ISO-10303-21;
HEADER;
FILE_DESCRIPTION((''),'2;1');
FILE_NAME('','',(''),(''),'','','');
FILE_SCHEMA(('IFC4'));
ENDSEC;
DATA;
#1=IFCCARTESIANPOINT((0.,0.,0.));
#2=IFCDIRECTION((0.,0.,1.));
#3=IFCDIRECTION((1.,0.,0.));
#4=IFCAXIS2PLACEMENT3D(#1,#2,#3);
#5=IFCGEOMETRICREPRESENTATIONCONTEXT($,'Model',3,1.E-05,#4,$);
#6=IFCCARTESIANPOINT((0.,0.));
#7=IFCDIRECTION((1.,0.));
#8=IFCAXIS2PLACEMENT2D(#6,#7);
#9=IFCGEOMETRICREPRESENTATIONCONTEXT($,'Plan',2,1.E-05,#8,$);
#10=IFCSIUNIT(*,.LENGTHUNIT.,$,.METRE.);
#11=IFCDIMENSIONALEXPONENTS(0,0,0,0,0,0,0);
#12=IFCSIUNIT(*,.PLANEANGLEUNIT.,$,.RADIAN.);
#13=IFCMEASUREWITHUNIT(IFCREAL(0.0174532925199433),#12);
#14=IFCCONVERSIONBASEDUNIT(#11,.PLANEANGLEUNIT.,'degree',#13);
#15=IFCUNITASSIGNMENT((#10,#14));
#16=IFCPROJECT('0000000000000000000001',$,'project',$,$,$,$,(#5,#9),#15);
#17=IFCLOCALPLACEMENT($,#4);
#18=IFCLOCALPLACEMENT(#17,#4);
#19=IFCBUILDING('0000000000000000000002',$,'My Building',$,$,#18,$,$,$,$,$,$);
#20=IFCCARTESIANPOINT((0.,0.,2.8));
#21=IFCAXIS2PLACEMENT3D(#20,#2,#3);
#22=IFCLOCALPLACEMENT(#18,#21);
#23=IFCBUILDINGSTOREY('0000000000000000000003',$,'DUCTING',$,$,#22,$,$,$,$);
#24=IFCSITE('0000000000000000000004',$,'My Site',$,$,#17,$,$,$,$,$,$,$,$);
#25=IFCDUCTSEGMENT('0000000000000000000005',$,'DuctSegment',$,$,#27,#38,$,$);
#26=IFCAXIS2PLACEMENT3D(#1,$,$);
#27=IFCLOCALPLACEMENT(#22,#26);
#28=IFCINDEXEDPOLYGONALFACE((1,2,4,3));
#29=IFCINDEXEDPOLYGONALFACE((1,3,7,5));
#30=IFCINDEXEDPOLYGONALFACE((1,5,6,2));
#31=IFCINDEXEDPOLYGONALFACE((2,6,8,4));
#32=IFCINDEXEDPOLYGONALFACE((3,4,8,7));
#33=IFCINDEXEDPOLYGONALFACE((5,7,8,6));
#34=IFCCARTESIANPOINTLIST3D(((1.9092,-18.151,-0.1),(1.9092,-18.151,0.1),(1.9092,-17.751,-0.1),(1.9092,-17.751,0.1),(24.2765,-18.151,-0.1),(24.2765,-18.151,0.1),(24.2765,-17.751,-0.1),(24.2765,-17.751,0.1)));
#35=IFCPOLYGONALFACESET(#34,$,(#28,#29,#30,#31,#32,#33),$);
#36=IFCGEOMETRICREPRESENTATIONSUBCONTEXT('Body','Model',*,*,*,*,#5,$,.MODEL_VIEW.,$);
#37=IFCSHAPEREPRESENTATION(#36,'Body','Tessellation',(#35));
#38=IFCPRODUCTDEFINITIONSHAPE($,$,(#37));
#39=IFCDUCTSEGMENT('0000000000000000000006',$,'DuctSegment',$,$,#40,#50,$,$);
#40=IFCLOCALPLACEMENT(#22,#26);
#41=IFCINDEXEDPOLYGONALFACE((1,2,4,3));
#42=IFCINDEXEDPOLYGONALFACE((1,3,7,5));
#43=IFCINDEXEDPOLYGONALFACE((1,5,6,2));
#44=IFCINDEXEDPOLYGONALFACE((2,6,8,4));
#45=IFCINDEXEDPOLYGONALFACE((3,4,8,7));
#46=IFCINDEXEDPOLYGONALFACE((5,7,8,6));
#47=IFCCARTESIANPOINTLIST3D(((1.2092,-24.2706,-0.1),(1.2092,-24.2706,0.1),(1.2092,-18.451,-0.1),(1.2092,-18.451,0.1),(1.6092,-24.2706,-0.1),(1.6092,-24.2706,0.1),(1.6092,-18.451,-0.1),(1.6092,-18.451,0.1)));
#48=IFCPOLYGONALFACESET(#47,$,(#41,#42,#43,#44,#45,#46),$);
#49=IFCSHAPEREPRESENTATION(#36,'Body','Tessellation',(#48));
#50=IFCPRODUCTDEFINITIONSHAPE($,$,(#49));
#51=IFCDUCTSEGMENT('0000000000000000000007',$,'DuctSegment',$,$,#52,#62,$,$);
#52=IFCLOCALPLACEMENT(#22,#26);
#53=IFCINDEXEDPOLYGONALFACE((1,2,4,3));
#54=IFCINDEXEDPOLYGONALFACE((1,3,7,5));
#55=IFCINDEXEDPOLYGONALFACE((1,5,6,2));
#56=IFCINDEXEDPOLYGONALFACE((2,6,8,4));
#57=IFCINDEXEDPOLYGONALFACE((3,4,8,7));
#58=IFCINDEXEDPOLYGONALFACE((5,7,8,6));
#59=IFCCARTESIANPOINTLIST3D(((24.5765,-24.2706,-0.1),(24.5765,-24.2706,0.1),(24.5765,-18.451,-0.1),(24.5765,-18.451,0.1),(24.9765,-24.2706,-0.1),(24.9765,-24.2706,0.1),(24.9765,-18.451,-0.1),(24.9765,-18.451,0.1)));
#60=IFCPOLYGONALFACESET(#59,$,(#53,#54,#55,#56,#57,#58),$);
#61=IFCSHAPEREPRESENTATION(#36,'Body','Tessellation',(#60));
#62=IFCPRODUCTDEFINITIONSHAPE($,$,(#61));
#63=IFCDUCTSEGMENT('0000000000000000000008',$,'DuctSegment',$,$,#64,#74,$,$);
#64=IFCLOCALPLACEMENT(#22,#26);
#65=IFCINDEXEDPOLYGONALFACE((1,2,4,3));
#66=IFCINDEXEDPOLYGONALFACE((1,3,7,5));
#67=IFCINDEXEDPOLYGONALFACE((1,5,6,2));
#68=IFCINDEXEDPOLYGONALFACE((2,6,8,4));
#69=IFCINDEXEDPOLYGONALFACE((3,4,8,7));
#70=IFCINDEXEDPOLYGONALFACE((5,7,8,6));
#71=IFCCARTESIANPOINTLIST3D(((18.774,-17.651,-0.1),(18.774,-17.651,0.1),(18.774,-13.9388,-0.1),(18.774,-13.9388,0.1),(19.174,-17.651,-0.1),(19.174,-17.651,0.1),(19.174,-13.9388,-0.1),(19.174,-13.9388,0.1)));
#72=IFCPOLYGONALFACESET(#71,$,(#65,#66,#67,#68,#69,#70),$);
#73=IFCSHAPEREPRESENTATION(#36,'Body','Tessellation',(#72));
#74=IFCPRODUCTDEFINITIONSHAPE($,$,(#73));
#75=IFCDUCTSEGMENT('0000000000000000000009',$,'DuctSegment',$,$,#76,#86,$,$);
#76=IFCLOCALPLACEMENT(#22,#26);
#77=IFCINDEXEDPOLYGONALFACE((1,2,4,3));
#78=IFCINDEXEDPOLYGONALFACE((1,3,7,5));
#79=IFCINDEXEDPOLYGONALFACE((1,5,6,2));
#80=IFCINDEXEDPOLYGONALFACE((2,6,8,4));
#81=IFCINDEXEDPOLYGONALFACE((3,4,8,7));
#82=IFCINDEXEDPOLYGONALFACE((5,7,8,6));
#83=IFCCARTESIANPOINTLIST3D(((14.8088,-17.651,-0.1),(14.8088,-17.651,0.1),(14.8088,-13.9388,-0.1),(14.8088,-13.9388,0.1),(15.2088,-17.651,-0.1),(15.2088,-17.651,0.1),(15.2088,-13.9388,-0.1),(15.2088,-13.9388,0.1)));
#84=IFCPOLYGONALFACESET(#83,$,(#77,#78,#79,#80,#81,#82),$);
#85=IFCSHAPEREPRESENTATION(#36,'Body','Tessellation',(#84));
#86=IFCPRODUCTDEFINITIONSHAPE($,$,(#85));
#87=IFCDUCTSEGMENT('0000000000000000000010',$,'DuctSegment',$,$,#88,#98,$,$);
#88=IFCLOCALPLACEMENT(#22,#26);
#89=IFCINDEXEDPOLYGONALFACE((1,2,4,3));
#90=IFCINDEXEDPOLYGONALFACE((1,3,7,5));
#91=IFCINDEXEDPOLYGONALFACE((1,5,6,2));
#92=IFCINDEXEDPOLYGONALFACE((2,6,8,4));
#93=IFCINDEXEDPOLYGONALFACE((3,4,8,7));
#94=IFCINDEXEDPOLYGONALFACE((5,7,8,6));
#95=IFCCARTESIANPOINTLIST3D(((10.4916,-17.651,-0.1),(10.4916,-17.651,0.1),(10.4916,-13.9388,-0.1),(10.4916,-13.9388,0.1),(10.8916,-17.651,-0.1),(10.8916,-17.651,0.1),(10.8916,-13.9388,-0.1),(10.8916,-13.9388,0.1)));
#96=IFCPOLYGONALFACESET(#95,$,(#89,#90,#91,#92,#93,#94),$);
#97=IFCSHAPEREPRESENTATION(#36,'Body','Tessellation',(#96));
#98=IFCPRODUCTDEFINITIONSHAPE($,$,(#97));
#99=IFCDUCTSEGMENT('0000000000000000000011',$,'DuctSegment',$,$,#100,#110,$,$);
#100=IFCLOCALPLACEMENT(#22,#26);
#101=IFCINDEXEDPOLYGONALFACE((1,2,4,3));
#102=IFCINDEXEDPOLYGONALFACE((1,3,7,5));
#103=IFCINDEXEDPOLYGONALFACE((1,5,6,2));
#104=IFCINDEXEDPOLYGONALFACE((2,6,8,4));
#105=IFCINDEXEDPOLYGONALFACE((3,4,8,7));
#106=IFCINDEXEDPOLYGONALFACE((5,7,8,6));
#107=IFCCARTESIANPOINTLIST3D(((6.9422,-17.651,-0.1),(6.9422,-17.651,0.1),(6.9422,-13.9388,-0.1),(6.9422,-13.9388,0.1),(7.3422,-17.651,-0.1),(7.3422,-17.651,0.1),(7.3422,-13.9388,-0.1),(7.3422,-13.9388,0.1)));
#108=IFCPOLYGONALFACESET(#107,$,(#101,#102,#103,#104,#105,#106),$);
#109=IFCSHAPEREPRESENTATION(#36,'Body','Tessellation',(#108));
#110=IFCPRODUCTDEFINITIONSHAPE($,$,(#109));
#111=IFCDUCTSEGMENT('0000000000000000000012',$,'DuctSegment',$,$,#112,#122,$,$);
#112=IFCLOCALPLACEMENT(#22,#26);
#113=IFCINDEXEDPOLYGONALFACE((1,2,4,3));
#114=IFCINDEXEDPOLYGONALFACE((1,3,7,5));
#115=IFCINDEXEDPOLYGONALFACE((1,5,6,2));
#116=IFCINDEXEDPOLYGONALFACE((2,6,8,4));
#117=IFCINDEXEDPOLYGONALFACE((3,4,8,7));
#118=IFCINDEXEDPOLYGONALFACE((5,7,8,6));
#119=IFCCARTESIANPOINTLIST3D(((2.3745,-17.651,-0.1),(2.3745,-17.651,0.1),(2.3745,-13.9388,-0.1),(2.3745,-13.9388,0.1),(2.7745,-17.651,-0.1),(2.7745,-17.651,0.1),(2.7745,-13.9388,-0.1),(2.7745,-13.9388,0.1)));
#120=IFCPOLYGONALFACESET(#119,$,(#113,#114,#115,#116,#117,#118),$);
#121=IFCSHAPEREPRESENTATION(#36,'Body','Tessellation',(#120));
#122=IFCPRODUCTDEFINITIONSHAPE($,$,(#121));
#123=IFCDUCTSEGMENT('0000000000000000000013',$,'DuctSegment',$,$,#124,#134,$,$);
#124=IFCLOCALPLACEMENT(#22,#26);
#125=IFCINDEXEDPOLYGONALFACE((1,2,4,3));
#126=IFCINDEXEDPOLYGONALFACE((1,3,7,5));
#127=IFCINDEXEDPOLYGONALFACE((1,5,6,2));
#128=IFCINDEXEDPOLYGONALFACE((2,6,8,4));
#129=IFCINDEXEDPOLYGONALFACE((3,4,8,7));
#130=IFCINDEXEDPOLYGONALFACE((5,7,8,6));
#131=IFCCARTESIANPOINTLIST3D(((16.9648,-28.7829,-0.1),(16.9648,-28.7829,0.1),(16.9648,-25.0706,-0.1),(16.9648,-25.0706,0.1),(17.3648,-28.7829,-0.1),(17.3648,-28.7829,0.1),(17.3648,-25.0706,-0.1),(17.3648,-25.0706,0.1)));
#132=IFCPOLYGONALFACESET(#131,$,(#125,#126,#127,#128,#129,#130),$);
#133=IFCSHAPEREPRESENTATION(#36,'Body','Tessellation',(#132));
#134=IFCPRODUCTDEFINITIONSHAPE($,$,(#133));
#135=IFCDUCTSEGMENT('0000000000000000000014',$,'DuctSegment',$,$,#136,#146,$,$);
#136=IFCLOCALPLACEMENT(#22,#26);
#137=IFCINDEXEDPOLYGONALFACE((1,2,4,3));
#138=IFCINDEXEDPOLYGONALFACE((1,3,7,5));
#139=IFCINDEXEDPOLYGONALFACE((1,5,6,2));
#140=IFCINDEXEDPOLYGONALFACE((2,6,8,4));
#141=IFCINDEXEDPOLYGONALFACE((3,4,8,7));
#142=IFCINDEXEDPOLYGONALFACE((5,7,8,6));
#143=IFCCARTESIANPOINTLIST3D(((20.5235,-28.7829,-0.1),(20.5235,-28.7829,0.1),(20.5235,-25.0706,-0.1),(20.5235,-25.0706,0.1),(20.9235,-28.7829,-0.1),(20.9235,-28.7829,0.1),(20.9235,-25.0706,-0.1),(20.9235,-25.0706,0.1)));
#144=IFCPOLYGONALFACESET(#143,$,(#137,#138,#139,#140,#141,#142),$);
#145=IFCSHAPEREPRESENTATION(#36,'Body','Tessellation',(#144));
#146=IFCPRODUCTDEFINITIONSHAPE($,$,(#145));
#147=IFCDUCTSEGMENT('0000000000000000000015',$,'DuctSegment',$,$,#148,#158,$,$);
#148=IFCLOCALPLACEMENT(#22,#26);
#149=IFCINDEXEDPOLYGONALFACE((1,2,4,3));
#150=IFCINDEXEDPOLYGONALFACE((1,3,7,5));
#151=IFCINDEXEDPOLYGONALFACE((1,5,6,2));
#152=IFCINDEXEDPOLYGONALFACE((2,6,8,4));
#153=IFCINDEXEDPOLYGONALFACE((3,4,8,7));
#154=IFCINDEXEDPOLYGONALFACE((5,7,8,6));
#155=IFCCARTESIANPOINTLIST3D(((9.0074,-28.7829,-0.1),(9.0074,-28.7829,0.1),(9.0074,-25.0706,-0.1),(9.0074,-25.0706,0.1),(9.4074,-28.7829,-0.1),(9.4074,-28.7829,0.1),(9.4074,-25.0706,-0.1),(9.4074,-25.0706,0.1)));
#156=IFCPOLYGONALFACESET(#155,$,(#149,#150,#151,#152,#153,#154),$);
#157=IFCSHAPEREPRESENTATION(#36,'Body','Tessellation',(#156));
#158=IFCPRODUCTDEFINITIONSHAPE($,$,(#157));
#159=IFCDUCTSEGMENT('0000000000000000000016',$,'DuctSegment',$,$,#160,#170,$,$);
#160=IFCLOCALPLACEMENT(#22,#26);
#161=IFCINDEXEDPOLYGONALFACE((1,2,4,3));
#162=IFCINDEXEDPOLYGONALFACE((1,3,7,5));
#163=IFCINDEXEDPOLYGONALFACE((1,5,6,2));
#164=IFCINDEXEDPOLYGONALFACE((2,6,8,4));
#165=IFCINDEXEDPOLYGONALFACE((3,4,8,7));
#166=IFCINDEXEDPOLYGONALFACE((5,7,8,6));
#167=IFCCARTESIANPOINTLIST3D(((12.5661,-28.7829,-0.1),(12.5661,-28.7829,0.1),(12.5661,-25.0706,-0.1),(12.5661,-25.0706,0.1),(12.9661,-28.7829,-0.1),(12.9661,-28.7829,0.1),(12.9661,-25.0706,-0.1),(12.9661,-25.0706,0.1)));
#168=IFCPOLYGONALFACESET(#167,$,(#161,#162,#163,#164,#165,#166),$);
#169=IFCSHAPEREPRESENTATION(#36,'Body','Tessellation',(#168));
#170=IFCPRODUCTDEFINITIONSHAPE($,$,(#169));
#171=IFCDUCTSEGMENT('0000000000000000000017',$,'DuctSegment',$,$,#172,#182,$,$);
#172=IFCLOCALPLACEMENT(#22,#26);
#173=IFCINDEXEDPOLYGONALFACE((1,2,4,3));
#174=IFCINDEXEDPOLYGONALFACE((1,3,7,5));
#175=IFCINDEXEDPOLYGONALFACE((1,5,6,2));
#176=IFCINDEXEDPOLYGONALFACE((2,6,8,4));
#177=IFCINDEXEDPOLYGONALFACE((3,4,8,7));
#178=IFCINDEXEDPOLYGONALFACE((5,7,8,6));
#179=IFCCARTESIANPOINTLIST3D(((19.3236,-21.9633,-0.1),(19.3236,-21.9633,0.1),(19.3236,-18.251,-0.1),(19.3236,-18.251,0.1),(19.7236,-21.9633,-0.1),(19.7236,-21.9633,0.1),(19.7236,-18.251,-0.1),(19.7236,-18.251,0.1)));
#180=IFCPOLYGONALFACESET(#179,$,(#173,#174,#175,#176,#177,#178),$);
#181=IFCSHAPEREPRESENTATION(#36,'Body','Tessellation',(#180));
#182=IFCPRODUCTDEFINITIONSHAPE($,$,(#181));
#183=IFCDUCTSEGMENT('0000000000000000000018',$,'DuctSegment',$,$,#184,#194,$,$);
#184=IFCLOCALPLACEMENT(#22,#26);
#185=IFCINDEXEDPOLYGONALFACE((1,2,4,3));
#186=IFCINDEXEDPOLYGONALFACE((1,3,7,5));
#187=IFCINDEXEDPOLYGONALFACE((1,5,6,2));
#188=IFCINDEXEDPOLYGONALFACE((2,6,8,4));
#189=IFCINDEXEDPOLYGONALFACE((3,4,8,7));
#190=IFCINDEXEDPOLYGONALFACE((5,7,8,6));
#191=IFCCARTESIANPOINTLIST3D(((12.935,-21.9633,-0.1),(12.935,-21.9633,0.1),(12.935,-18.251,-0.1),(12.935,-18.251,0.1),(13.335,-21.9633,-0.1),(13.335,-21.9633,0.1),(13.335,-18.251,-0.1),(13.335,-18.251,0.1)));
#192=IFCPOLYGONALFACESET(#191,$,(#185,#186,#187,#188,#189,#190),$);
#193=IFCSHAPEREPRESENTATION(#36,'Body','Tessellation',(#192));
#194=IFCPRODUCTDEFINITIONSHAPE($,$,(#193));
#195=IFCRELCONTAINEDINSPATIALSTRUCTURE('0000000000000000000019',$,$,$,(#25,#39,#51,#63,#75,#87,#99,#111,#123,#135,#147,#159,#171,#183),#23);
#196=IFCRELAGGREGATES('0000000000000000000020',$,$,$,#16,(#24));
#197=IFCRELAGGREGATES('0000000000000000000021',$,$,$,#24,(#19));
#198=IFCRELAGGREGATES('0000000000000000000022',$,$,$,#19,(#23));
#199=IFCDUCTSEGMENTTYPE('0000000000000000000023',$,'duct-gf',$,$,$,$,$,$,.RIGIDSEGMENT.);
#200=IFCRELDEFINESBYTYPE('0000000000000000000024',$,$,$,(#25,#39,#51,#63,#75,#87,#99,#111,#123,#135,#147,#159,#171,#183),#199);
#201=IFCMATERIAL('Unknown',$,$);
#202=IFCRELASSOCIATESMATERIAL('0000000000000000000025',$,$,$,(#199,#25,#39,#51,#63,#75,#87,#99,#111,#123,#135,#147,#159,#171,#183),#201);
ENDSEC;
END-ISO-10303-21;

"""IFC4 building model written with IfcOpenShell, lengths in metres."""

from ifc_helpers import new_model, entity, si_unit, converted_unit, frame, origin_with_axes, origin_2d_with_axis, place, context, subcontext, project, spatial, rectangle, extrude, material, material_profile, profile_set, profile_usage, type_object, element, save


model = new_model("IFC4")

# Units and contexts
model_context = context("Model", 3, precision=1e-05, world=origin_with_axes())
plan_context = context("Plan", 2, precision=1e-05, world=origin_2d_with_axis())
body_context = subcontext(model_context, "Body", "Model", "MODEL_VIEW")
ifc_project = project(units=[si_unit("LENGTHUNIT", "METRE"), converted_unit("PLANEANGLEUNIT", "degree", entity("IfcReal", 0.0174532925199433), si_unit("PLANEANGLEUNIT", "RADIAN"), dimensions=[0, 0, 0, 0, 0, 0, 0])], contexts=[model_context, plan_context])

# Site, building, storey
site_placement = place(None, origin_with_axes())
site = spatial("IfcSite", under=ifc_project, at=site_placement, Name="My Site")
building_placement = place(site_placement, origin_with_axes())
building = spatial("IfcBuilding", under=site, at=building_placement, Name="My Building")
storey_placement = place(building_placement, frame((0.0, 0.0, 2.8), z_axis=(0.0, 0.0, 1.0), x_axis=(1.0, 0.0, 0.0)))
storey = spatial("IfcBuildingStorey", under=building, at=storey_placement, Name="DUCTING")

# Duct segments
ifc_material = material(Name="Unknown")
ifc_material_profile = material_profile(ifc_material, rectangle(XDim=0.4, YDim=0.2))
ifc_profile_set = profile_set([ifc_material_profile])
ifc_profile_usage_1 = profile_usage(ifc_profile_set, cardinal=5)
duct_segment_type = type_object("IfcDuctSegmentType", Name="duct-gf", PredefinedType="RIGIDSEGMENT", material=ifc_profile_set)
duct_segment_1_placement = place(storey_placement, frame((1.9092, -17.951, 0.0), z_axis=(1.0, -0.000001, 0.000001), x_axis=(0.000001, 1.0, 0.0)))
element("IfcDuctSegment", 1, at=duct_segment_1_placement, inside=storey, type_object=duct_segment_type, material=ifc_profile_usage_1, Name="DuctSegment", context=body_context, shape_type="SweptSolid", body=[
    extrude(rectangle(XDim=0.4, YDim=0.2), origin_with_axes(), (0.0, 0.0, 1.0), 22.3674),
])
ifc_profile_usage_2 = profile_usage(ifc_profile_set, cardinal=5)
duct_segment_2_placement = place(storey_placement, frame((1.4092, -18.451, 0.0), z_axis=(0.0, -1.0, 0.0), x_axis=(1.0, 0.0, 0.0)))
element("IfcDuctSegment", 2, at=duct_segment_2_placement, inside=storey, type_object=duct_segment_type, material=ifc_profile_usage_2, Name="DuctSegment", context=body_context, shape_type="SweptSolid", body=[
    extrude(rectangle(XDim=0.4, YDim=0.2), origin_with_axes(), (0.0, 0.0, 1.0), 5.8196),
])
ifc_profile_usage_3 = profile_usage(ifc_profile_set, cardinal=5)
duct_segment_3_placement = place(storey_placement, frame((24.7765, -18.451, 0.0), z_axis=(0.0, -1.0, 0.0), x_axis=(1.0, 0.0, 0.0)))
element("IfcDuctSegment", 3, at=duct_segment_3_placement, inside=storey, type_object=duct_segment_type, material=ifc_profile_usage_3, Name="DuctSegment", context=body_context, shape_type="SweptSolid", body=[
    extrude(rectangle(XDim=0.4, YDim=0.2), origin_with_axes(), (0.0, 0.0, 1.0), 5.8196),
])
ifc_profile_usage_4 = profile_usage(ifc_profile_set, cardinal=5)
duct_segment_4_placement = place(storey_placement, frame((18.974, -13.9388, 0.0), z_axis=(0.0, -1.0, 0.0), x_axis=(1.0, 0.0, 0.0)))
element("IfcDuctSegment", 4, at=duct_segment_4_placement, inside=storey, type_object=duct_segment_type, material=ifc_profile_usage_4, Name="DuctSegment", context=body_context, shape_type="SweptSolid", body=[
    extrude(rectangle(XDim=0.4, YDim=0.2), origin_with_axes(), (0.0, 0.0, 1.0), 3.7122),
])
ifc_profile_usage_5 = profile_usage(ifc_profile_set, cardinal=5)
duct_segment_5_placement = place(storey_placement, frame((15.0088, -13.9388, 0.0), z_axis=(0.0, -1.0, 0.0), x_axis=(1.0, 0.0, 0.0)))
element("IfcDuctSegment", 5, at=duct_segment_5_placement, inside=storey, type_object=duct_segment_type, material=ifc_profile_usage_5, Name="DuctSegment", context=body_context, shape_type="SweptSolid", body=[
    extrude(rectangle(XDim=0.4, YDim=0.2), origin_with_axes(), (0.0, 0.0, 1.0), 3.7122),
])
ifc_profile_usage_6 = profile_usage(ifc_profile_set, cardinal=5)
duct_segment_6_placement = place(storey_placement, frame((10.6916, -13.9388, 0.0), z_axis=(0.0, -1.0, 0.0), x_axis=(1.0, 0.0, 0.0)))
element("IfcDuctSegment", 6, at=duct_segment_6_placement, inside=storey, type_object=duct_segment_type, material=ifc_profile_usage_6, Name="DuctSegment", context=body_context, shape_type="SweptSolid", body=[
    extrude(rectangle(XDim=0.4, YDim=0.2), origin_with_axes(), (0.0, 0.0, 1.0), 3.7122),
])
ifc_profile_usage_7 = profile_usage(ifc_profile_set, cardinal=5)
duct_segment_7_placement = place(storey_placement, frame((7.1422, -13.9388, 0.0), z_axis=(0.0, -1.0, 0.0), x_axis=(1.0, 0.0, 0.0)))
element("IfcDuctSegment", 7, at=duct_segment_7_placement, inside=storey, type_object=duct_segment_type, material=ifc_profile_usage_7, Name="DuctSegment", context=body_context, shape_type="SweptSolid", body=[
    extrude(rectangle(XDim=0.4, YDim=0.2), origin_with_axes(), (0.0, 0.0, 1.0), 3.7122),
])
ifc_profile_usage_8 = profile_usage(ifc_profile_set, cardinal=5)
duct_segment_8_placement = place(storey_placement, frame((2.5745, -13.9388, 0.0), z_axis=(0.0, -1.0, 0.0), x_axis=(1.0, 0.0, 0.0)))
element("IfcDuctSegment", 8, at=duct_segment_8_placement, inside=storey, type_object=duct_segment_type, material=ifc_profile_usage_8, Name="DuctSegment", context=body_context, shape_type="SweptSolid", body=[
    extrude(rectangle(XDim=0.4, YDim=0.2), origin_with_axes(), (0.0, 0.0, 1.0), 3.7122),
])
ifc_profile_usage_9 = profile_usage(ifc_profile_set, cardinal=5)
duct_segment_9_placement = place(storey_placement, frame((17.1648, -28.7829, 0.0), z_axis=(0.0, 1.0, 0.0), x_axis=(-1.0, 0.0, 0.0)))
element("IfcDuctSegment", 9, at=duct_segment_9_placement, inside=storey, type_object=duct_segment_type, material=ifc_profile_usage_9, Name="DuctSegment", context=body_context, shape_type="SweptSolid", body=[
    extrude(rectangle(XDim=0.4, YDim=0.2), origin_with_axes(), (0.0, 0.0, 1.0), 3.7122),
])
ifc_profile_usage_10 = profile_usage(ifc_profile_set, cardinal=5)
duct_segment_10_placement = place(storey_placement, frame((20.7235, -28.7829, 0.0), z_axis=(0.0, 1.0, 0.0), x_axis=(-1.0, 0.0, 0.0)))
element("IfcDuctSegment", 10, at=duct_segment_10_placement, inside=storey, type_object=duct_segment_type, material=ifc_profile_usage_10, Name="DuctSegment", context=body_context, shape_type="SweptSolid", body=[
    extrude(rectangle(XDim=0.4, YDim=0.2), origin_with_axes(), (0.0, 0.0, 1.0), 3.7122),
])
ifc_profile_usage_11 = profile_usage(ifc_profile_set, cardinal=5)
duct_segment_11_placement = place(storey_placement, frame((9.2074, -28.7829, 0.0), z_axis=(0.0, 1.0, 0.0), x_axis=(-1.0, 0.0, 0.0)))
element("IfcDuctSegment", 11, at=duct_segment_11_placement, inside=storey, type_object=duct_segment_type, material=ifc_profile_usage_11, Name="DuctSegment", context=body_context, shape_type="SweptSolid", body=[
    extrude(rectangle(XDim=0.4, YDim=0.2), origin_with_axes(), (0.0, 0.0, 1.0), 3.7122),
])
ifc_profile_usage_12 = profile_usage(ifc_profile_set, cardinal=5)
duct_segment_12_placement = place(storey_placement, frame((12.7661, -28.7829, 0.0), z_axis=(0.0, 1.0, 0.0), x_axis=(-1.0, 0.0, 0.0)))
element("IfcDuctSegment", 12, at=duct_segment_12_placement, inside=storey, type_object=duct_segment_type, material=ifc_profile_usage_12, Name="DuctSegment", context=body_context, shape_type="SweptSolid", body=[
    extrude(rectangle(XDim=0.4, YDim=0.2), origin_with_axes(), (0.0, 0.0, 1.0), 3.7122),
])
ifc_profile_usage_13 = profile_usage(ifc_profile_set, cardinal=5)
duct_segment_13_placement = place(storey_placement, frame((19.5236, -21.9633, 0.0), z_axis=(0.0, 1.0, 0.0), x_axis=(-1.0, 0.0, 0.0)))
element("IfcDuctSegment", 13, at=duct_segment_13_placement, inside=storey, type_object=duct_segment_type, material=ifc_profile_usage_13, Name="DuctSegment", context=body_context, shape_type="SweptSolid", body=[
    extrude(rectangle(XDim=0.4, YDim=0.2), origin_with_axes(), (0.0, 0.0, 1.0), 3.7122),
])
ifc_profile_usage_14 = profile_usage(ifc_profile_set, cardinal=5)
duct_segment_14_placement = place(storey_placement, frame((13.135, -21.9633, 0.0), z_axis=(0.0, 1.0, 0.0), x_axis=(-1.0, 0.0, 0.0)))
element("IfcDuctSegment", 14, at=duct_segment_14_placement, inside=storey, type_object=duct_segment_type, material=ifc_profile_usage_14, Name="DuctSegment", context=body_context, shape_type="SweptSolid", body=[
    extrude(rectangle(XDim=0.4, YDim=0.2), origin_with_axes(), (0.0, 0.0, 1.0), 3.7122),
])

save(model, "model.ifc")
